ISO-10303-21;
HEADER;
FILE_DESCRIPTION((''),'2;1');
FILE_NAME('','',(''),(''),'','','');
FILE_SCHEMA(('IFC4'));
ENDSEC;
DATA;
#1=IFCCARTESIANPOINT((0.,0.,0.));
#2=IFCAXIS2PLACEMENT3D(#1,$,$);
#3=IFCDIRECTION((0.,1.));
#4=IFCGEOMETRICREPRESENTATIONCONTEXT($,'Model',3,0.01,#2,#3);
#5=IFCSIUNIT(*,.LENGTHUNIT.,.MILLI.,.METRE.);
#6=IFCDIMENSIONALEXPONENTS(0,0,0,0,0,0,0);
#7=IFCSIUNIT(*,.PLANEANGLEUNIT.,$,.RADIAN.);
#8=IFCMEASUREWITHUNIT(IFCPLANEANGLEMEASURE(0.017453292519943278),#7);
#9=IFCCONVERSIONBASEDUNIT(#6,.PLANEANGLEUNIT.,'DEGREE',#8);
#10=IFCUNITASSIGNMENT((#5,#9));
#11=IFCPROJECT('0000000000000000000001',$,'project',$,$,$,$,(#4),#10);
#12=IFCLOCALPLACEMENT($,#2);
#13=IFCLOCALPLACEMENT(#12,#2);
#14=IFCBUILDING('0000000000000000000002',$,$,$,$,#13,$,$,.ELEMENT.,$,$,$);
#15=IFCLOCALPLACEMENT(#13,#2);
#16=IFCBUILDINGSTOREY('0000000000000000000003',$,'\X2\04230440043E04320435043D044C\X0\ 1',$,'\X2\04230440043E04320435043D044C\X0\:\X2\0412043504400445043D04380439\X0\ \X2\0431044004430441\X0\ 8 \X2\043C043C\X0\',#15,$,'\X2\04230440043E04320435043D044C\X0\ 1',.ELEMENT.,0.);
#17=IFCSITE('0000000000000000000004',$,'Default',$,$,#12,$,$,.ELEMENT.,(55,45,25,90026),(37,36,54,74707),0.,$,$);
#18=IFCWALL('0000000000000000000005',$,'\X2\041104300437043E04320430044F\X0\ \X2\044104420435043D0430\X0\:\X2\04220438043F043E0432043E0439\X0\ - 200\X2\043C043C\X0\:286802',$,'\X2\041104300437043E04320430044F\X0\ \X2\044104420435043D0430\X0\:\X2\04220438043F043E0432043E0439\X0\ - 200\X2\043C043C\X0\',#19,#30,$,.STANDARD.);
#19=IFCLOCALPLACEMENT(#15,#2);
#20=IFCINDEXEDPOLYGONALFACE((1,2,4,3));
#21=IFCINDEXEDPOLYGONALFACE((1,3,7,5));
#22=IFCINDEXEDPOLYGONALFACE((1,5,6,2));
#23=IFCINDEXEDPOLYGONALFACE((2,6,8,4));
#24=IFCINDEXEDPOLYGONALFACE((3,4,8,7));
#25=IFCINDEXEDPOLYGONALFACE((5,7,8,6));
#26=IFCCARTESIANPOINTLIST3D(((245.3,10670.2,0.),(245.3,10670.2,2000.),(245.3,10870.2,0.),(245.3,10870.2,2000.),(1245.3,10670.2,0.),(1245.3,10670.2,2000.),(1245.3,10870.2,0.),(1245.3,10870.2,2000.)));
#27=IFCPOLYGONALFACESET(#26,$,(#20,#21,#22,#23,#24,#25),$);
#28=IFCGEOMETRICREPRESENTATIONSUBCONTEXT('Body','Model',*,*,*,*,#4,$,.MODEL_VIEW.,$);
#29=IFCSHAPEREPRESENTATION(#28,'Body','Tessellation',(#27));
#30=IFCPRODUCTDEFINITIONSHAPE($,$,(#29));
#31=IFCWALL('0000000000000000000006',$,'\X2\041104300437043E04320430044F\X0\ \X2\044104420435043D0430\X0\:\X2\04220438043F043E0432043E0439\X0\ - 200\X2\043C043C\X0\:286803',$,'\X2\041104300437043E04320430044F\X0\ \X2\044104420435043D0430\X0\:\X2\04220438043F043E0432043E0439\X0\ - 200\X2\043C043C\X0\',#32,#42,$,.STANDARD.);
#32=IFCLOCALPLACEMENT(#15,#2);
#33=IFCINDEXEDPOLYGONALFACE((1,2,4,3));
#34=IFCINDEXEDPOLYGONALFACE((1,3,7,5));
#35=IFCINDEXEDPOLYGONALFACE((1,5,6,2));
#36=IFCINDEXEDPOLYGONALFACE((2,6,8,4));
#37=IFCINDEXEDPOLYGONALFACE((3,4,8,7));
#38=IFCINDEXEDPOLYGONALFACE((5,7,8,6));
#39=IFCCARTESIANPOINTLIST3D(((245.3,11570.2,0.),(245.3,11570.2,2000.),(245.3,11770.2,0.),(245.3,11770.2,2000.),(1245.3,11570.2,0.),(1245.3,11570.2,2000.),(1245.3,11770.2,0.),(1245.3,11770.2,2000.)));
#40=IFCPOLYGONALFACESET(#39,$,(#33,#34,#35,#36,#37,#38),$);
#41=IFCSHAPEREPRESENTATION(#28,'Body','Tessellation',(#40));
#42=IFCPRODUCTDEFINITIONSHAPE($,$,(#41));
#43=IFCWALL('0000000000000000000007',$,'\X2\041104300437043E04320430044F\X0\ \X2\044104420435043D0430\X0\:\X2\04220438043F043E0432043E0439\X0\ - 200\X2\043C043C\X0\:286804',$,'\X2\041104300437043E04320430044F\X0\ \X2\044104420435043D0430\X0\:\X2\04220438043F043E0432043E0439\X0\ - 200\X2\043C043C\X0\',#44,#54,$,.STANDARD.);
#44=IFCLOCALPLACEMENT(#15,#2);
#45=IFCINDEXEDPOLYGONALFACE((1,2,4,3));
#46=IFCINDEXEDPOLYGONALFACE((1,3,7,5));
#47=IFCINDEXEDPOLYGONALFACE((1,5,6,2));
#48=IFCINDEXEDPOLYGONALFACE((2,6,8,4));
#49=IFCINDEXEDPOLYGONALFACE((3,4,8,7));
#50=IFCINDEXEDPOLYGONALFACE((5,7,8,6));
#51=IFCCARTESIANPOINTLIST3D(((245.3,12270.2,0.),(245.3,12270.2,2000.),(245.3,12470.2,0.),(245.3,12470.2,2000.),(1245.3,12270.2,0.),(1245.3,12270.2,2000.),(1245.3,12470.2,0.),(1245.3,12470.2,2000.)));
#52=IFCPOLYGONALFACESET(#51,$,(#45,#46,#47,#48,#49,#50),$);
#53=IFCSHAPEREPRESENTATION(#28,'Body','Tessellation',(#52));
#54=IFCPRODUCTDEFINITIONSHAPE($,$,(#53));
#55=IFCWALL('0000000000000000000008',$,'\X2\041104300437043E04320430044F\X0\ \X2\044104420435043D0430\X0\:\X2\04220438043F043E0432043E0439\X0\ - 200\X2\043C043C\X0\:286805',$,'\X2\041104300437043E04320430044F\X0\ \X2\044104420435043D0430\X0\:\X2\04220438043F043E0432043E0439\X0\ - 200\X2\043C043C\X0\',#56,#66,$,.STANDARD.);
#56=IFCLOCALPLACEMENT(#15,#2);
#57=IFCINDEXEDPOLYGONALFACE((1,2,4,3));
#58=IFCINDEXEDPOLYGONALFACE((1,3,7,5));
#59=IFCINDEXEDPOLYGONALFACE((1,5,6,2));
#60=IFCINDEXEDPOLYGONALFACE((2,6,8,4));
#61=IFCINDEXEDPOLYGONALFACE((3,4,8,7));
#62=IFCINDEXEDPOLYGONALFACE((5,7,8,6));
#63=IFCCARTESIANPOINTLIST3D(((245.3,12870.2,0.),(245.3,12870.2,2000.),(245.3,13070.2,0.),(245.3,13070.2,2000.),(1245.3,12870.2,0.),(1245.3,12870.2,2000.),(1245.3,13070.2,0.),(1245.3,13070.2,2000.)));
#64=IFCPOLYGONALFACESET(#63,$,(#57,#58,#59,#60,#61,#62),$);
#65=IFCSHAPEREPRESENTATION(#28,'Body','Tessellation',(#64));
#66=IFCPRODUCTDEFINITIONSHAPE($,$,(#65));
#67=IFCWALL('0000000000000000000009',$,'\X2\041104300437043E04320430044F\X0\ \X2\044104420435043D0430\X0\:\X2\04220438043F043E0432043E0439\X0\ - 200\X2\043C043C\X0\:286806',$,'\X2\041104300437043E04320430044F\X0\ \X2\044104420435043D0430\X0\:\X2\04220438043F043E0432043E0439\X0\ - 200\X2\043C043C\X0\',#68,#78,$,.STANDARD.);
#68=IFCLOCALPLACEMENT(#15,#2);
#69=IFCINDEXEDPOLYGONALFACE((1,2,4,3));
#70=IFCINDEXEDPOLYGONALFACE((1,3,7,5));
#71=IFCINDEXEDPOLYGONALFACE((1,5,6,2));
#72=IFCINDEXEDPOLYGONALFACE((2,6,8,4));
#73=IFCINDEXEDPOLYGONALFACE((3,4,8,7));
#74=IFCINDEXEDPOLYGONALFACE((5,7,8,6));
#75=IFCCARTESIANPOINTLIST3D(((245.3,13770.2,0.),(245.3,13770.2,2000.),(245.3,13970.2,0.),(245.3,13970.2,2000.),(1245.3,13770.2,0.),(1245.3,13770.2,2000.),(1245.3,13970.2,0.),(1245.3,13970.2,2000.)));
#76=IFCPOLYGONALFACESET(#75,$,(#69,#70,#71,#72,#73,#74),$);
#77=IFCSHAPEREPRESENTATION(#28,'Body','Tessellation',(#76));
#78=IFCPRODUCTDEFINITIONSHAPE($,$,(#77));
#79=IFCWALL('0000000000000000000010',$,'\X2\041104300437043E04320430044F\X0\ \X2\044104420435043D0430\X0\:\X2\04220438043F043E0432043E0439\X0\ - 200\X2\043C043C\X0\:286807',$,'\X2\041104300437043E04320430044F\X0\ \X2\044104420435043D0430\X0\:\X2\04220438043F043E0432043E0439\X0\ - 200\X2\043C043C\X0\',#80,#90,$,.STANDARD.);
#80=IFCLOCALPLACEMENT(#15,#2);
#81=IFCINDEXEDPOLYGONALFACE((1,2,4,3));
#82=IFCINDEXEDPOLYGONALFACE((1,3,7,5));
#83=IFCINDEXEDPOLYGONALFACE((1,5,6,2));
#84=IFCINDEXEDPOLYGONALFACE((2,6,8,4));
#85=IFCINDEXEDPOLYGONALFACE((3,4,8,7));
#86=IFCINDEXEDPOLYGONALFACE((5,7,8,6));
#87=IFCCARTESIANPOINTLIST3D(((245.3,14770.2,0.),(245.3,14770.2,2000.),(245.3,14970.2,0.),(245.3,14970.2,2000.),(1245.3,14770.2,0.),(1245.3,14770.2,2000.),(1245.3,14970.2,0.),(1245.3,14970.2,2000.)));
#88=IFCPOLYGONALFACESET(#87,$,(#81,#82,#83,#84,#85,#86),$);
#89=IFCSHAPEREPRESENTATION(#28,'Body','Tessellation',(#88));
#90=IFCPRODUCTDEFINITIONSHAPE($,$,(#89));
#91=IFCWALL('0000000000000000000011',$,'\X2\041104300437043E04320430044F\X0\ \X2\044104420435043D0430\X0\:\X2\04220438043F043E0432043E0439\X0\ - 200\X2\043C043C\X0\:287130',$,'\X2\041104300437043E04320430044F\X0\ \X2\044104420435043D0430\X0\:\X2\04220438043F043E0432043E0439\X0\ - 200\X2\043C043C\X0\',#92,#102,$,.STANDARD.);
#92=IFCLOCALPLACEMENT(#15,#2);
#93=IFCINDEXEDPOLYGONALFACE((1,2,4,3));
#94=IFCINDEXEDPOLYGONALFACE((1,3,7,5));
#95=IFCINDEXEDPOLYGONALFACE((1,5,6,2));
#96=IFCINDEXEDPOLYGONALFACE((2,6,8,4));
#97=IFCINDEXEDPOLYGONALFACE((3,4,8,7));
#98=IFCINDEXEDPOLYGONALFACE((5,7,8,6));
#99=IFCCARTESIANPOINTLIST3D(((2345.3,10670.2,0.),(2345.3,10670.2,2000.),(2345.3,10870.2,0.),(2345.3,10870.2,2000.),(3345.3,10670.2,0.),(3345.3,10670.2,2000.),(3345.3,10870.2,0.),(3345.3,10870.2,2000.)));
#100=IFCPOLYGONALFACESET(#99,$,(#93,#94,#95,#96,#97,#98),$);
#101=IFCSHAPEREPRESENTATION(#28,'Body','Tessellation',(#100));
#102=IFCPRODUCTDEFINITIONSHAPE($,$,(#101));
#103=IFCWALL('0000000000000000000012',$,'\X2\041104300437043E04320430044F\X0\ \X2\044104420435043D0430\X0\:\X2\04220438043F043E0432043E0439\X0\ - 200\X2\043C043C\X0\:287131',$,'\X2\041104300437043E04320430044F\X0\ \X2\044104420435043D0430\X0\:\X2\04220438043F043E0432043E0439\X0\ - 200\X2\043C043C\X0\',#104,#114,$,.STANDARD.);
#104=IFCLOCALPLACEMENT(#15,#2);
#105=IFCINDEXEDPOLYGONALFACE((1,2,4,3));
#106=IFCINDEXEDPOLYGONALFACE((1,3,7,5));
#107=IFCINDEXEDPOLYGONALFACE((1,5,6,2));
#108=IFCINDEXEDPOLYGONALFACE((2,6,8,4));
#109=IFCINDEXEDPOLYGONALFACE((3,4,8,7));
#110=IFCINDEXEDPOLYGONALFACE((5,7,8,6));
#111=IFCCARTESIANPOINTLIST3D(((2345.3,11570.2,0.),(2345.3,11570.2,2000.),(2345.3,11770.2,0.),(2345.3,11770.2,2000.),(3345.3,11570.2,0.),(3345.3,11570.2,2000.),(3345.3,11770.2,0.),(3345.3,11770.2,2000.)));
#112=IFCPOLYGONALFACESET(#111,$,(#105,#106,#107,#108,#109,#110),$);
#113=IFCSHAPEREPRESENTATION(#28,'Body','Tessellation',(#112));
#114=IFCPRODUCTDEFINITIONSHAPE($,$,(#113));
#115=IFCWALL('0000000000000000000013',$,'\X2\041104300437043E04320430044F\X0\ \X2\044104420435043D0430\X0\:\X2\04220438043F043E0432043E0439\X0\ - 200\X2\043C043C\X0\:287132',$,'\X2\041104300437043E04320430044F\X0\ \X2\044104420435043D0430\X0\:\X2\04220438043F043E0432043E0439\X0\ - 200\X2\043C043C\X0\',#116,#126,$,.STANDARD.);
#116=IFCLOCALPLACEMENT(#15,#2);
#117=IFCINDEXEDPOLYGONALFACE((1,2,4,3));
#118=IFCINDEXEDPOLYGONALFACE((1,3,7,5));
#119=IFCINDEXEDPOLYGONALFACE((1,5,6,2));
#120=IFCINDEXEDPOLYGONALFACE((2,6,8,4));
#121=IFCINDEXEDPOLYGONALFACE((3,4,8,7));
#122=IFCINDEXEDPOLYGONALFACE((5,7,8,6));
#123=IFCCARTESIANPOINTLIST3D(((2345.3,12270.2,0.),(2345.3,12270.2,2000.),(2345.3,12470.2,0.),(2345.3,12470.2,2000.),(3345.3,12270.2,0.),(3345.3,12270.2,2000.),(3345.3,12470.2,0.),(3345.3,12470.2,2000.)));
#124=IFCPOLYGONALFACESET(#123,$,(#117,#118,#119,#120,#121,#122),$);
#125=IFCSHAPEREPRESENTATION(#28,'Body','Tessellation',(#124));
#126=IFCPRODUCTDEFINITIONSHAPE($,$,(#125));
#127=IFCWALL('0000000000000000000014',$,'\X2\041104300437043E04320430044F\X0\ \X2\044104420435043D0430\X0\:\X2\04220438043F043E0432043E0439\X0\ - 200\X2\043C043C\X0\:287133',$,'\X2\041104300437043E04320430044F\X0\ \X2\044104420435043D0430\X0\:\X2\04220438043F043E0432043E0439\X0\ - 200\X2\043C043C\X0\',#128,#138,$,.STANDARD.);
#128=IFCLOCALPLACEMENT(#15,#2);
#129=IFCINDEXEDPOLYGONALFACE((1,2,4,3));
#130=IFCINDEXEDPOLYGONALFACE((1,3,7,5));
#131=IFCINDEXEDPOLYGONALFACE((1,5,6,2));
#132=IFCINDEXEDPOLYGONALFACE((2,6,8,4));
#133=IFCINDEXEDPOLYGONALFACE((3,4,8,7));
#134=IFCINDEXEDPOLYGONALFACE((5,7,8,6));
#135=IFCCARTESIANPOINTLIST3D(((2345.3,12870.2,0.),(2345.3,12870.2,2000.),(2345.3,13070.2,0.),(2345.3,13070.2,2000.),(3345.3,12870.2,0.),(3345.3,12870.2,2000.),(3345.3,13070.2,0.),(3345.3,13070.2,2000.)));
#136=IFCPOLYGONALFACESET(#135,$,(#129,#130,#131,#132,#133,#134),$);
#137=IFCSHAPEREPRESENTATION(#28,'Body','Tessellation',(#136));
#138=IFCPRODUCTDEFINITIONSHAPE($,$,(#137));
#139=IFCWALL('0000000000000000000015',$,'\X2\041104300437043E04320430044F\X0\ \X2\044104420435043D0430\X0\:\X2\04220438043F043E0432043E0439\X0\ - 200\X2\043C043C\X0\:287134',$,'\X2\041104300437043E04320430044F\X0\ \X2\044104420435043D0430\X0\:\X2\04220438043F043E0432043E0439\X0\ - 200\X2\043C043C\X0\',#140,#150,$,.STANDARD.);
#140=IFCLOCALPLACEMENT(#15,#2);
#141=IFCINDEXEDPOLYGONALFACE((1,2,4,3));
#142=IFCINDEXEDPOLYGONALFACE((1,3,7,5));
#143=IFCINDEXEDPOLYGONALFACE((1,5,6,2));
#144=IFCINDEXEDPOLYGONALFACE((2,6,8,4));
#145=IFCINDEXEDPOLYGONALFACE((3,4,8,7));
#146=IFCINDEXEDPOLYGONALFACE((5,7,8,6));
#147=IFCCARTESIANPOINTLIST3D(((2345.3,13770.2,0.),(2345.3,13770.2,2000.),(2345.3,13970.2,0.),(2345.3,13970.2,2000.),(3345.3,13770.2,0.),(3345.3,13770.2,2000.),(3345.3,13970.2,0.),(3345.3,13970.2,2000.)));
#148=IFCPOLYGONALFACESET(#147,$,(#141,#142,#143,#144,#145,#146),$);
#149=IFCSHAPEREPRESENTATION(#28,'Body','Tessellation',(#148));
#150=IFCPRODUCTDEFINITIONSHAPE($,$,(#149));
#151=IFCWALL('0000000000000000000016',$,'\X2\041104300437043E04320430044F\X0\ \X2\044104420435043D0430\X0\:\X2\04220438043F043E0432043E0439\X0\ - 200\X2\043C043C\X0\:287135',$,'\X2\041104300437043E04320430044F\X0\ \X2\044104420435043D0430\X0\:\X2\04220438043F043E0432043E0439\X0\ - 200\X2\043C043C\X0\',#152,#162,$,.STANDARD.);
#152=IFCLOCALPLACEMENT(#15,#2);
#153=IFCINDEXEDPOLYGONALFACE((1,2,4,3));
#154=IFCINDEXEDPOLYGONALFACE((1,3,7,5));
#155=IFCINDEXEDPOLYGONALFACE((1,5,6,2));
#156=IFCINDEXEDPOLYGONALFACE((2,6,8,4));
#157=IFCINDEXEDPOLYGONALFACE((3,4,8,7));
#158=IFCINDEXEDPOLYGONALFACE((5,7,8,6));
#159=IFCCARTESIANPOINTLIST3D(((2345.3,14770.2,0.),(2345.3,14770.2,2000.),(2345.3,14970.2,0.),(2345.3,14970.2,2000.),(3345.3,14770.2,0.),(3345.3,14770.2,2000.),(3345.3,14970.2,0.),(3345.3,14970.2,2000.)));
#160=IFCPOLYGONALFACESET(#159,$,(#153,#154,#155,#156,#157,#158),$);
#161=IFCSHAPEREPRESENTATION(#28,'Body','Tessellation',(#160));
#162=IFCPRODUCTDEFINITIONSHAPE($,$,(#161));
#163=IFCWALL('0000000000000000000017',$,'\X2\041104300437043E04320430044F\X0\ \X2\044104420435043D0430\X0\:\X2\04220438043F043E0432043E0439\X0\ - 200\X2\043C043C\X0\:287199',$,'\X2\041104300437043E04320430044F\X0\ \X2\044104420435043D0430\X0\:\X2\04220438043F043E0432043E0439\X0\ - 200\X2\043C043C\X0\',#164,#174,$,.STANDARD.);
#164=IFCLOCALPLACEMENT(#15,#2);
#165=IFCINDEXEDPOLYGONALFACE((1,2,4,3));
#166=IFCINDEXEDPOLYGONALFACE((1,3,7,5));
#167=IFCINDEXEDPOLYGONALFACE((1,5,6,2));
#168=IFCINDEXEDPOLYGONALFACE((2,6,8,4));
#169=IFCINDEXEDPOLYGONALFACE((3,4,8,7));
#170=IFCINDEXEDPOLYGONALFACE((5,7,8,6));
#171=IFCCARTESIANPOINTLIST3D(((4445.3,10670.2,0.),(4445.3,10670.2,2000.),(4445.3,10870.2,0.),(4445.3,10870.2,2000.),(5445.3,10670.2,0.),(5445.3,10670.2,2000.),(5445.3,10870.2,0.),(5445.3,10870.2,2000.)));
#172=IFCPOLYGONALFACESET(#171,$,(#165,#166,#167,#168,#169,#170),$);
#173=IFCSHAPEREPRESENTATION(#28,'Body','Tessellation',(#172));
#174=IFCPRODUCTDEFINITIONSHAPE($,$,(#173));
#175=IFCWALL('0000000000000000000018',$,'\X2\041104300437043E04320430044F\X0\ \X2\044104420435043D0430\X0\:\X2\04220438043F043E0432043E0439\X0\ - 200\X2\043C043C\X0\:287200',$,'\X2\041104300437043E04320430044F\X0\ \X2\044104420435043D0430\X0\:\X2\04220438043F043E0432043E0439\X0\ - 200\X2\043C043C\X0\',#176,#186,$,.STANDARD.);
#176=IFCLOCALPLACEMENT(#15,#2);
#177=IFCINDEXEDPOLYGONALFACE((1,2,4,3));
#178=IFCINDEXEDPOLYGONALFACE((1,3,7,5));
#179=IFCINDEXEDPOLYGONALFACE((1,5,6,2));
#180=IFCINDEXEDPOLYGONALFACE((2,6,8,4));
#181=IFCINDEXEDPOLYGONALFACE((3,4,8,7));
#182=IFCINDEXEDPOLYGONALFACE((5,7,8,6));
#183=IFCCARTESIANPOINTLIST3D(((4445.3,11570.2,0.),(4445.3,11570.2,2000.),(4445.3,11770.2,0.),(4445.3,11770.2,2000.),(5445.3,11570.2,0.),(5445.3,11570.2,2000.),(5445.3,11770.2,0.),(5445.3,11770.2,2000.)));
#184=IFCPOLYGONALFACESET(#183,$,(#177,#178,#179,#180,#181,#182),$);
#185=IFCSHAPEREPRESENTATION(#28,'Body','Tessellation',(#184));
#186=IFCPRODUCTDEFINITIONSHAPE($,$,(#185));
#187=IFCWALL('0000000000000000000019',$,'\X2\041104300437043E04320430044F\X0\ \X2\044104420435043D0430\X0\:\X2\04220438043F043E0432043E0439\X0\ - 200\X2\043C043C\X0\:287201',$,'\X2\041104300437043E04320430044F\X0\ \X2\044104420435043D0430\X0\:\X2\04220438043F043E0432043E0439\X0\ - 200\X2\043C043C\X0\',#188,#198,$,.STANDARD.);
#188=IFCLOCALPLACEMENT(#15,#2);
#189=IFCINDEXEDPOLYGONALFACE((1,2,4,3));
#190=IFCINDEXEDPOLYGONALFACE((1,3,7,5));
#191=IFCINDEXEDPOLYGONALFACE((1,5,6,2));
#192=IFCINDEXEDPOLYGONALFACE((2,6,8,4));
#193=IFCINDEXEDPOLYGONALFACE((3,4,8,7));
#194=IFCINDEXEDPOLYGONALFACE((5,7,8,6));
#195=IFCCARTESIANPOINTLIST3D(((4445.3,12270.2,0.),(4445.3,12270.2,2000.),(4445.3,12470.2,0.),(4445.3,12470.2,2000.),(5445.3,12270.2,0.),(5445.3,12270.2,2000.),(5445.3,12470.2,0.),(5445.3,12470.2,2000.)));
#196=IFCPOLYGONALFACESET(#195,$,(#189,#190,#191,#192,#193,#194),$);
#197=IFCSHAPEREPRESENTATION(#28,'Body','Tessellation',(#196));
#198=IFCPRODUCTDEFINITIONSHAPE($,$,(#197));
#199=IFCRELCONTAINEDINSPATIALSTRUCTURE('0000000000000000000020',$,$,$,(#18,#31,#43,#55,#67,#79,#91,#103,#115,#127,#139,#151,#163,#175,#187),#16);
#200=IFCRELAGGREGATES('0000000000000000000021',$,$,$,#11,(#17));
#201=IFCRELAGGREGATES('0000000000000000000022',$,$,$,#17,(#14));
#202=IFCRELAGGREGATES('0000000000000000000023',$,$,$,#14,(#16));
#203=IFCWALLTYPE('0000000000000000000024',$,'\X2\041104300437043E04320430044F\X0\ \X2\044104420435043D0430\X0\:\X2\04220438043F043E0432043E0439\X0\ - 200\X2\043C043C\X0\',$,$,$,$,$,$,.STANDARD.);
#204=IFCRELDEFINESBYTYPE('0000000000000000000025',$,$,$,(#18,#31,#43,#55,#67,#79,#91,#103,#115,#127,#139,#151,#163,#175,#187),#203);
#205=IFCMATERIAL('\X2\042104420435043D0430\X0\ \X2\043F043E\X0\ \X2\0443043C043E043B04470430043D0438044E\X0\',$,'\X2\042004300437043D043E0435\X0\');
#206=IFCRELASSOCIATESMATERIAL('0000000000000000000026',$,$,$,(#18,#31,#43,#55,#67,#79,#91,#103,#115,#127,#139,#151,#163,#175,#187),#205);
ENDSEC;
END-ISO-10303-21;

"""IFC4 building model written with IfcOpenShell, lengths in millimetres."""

from ifc_helpers import new_model, entity, si_unit, converted_unit, direction, frame, origin, place, context, subcontext, project, spatial, indexed_curve, outline, extrude, material, type_object, element, save


model = new_model("IFC4")

# Units and contexts
model_context = context("Model", 3, precision=0.01, world=origin(), true_north=direction((0.0, 1.0)))
body_context = subcontext(model_context, "Body", "Model", "MODEL_VIEW")
ifc_project = project(units=[si_unit("LENGTHUNIT", "METRE", prefix="MILLI"), converted_unit("PLANEANGLEUNIT", "DEGREE", entity("IfcPlaneAngleMeasure", 0.017453292519943278), si_unit("PLANEANGLEUNIT", "RADIAN"), dimensions=[0, 0, 0, 0, 0, 0, 0])], contexts=[model_context])

# Site, building, storey
site_placement = place(None, origin())
site = spatial("IfcSite", under=ifc_project, at=site_placement, Name="Default", CompositionType="ELEMENT", RefLatitude=(55, 45, 25, 90026), RefLongitude=(37, 36, 54, 74707), RefElevation=0.0)
building_placement = place(site_placement, origin())
building = spatial("IfcBuilding", under=site, at=building_placement, CompositionType="ELEMENT")
storey_placement = place(building_placement, origin())
storey = spatial("IfcBuildingStorey", under=building, at=storey_placement, Name="Уровень 1", ObjectType="Уровень:Верхний брус 8 мм", LongName="Уровень 1", CompositionType="ELEMENT", Elevation=0.0)

# Walls
ifc_material = material(Name="Стена по умолчанию", Category="Разное")
wall_type = type_object("IfcWallType", Name="Базовая стена:Типовой - 200мм", PredefinedType="STANDARD")
wall_1_placement = place(storey_placement, frame((245.3, 10770.2, 0.0)))
element("IfcWall", 1, at=wall_1_placement, inside=storey, type_object=wall_type, material=ifc_material, Name="Базовая стена:Типовой - 200мм:286802", ObjectType="Базовая стена:Типовой - 200мм", PredefinedType="STANDARD", context=body_context, shape_type="SweptSolid", body=[
    extrude(outline(indexed_curve([(1000.0, 100.0), (0.0, 100.0), (0.0, -100.0), (1000.0, -100.0), (1000.0, 100.0)], self_intersect=False)), origin(), (0.0, 0.0, 1.0), 2000.0),
])
for number, where, name in (
    (2, (245.3, 11670.2, 0.0), "Базовая стена:Типовой - 200мм:286803"),
    (3, (245.3, 12370.2, 0.0), "Базовая стена:Типовой - 200мм:286804"),
):
    element("IfcWall", number, at=place(storey_placement, frame(where)), inside=storey, type_object=wall_type, material=ifc_material, Name=name, ObjectType="Базовая стена:Типовой - 200мм", PredefinedType="STANDARD", context=body_context, shape_type="SweptSolid", body=[
        extrude(outline(indexed_curve([(1000.0, 100.0), (0.0, 100.0), (0.0, -100.0), (1000.0, -100.0), (1000.0, 100.0)], self_intersect=False)), origin(), (0.0, 0.0, 1.0), 2000.0),
    ])
wall_2_placement = place(storey_placement, frame((245.3, 12970.2, 0.0)))
element("IfcWall", 4, at=wall_2_placement, inside=storey, type_object=wall_type, material=ifc_material, Name="Базовая стена:Типовой - 200мм:286805", ObjectType="Базовая стена:Типовой - 200мм", PredefinedType="STANDARD", context=body_context, shape_type="SweptSolid", body=[
    extrude(outline(indexed_curve([(1000.0, 100.0), (0.0, 100.0), (0.0, -100.0), (1000.0, -100.0), (1000.0, 100.0)], self_intersect=False)), origin(), (0.0, 0.0, 1.0), 2000.0),
])
wall_3_placement = place(storey_placement, frame((245.3, 13870.2, 0.0)))
element("IfcWall", 5, at=wall_3_placement, inside=storey, type_object=wall_type, material=ifc_material, Name="Базовая стена:Типовой - 200мм:286806", ObjectType="Базовая стена:Типовой - 200мм", PredefinedType="STANDARD", context=body_context, shape_type="SweptSolid", body=[
    extrude(outline(indexed_curve([(1000.0, 100.0), (0.0, 100.0), (0.0, -100.0), (1000.0, -100.0), (1000.0, 100.0)], self_intersect=False)), origin(), (0.0, 0.0, 1.0), 2000.0),
])
wall_4_placement = place(storey_placement, frame((245.3, 14870.2, 0.0)))
element("IfcWall", 6, at=wall_4_placement, inside=storey, type_object=wall_type, material=ifc_material, Name="Базовая стена:Типовой - 200мм:286807", ObjectType="Базовая стена:Типовой - 200мм", PredefinedType="STANDARD", context=body_context, shape_type="SweptSolid", body=[
    extrude(outline(indexed_curve([(1000.0, 100.0), (0.0, 100.0), (0.0, -100.0), (1000.0, -100.0), (1000.0, 100.0)], self_intersect=False)), origin(), (0.0, 0.0, 1.0), 2000.0),
])
wall_5_placement = place(storey_placement, frame((2345.3, 10770.2, 0.0)))
element("IfcWall", 7, at=wall_5_placement, inside=storey, type_object=wall_type, material=ifc_material, Name="Базовая стена:Типовой - 200мм:287130", ObjectType="Базовая стена:Типовой - 200мм", PredefinedType="STANDARD", context=body_context, shape_type="SweptSolid", body=[
    extrude(outline(indexed_curve([(1000.0, 100.0), (0.0, 100.0), (0.0, -100.0), (1000.0, -100.0), (1000.0, 100.0)], self_intersect=False)), origin(), (0.0, 0.0, 1.0), 2000.0),
])
for number, where, name in (
    (8, (2345.3, 11670.2, 0.0), "Базовая стена:Типовой - 200мм:287131"),
    (9, (2345.3, 12370.2, 0.0), "Базовая стена:Типовой - 200мм:287132"),
):
    element("IfcWall", number, at=place(storey_placement, frame(where)), inside=storey, type_object=wall_type, material=ifc_material, Name=name, ObjectType="Базовая стена:Типовой - 200мм", PredefinedType="STANDARD", context=body_context, shape_type="SweptSolid", body=[
        extrude(outline(indexed_curve([(1000.0, 100.0), (0.0, 100.0), (0.0, -100.0), (1000.0, -100.0), (1000.0, 100.0)], self_intersect=False)), origin(), (0.0, 0.0, 1.0), 2000.0),
    ])
wall_6_placement = place(storey_placement, frame((2345.3, 12970.2, 0.0)))
element("IfcWall", 10, at=wall_6_placement, inside=storey, type_object=wall_type, material=ifc_material, Name="Базовая стена:Типовой - 200мм:287133", ObjectType="Базовая стена:Типовой - 200мм", PredefinedType="STANDARD", context=body_context, shape_type="SweptSolid", body=[
    extrude(outline(indexed_curve([(1000.0, 100.0), (0.0, 100.0), (0.0, -100.0), (1000.0, -100.0), (1000.0, 100.0)], self_intersect=False)), origin(), (0.0, 0.0, 1.0), 2000.0),
])
wall_7_placement = place(storey_placement, frame((2345.3, 13870.2, 0.0)))
element("IfcWall", 11, at=wall_7_placement, inside=storey, type_object=wall_type, material=ifc_material, Name="Базовая стена:Типовой - 200мм:287134", ObjectType="Базовая стена:Типовой - 200мм", PredefinedType="STANDARD", context=body_context, shape_type="SweptSolid", body=[
    extrude(outline(indexed_curve([(1000.0, 100.0), (0.0, 100.0), (0.0, -100.0), (1000.0, -100.0), (1000.0, 100.0)], self_intersect=False)), origin(), (0.0, 0.0, 1.0), 2000.0),
])
wall_8_placement = place(storey_placement, frame((2345.3, 14870.2, 0.0)))
element("IfcWall", 12, at=wall_8_placement, inside=storey, type_object=wall_type, material=ifc_material, Name="Базовая стена:Типовой - 200мм:287135", ObjectType="Базовая стена:Типовой - 200мм", PredefinedType="STANDARD", context=body_context, shape_type="SweptSolid", body=[
    extrude(outline(indexed_curve([(1000.0, 100.0), (0.0, 100.0), (0.0, -100.0), (1000.0, -100.0), (1000.0, 100.0)], self_intersect=False)), origin(), (0.0, 0.0, 1.0), 2000.0),
])
wall_9_placement = place(storey_placement, frame((4445.3, 10770.2, 0.0)))
element("IfcWall", 13, at=wall_9_placement, inside=storey, type_object=wall_type, material=ifc_material, Name="Базовая стена:Типовой - 200мм:287199", ObjectType="Базовая стена:Типовой - 200мм", PredefinedType="STANDARD", context=body_context, shape_type="SweptSolid", body=[
    extrude(outline(indexed_curve([(1000.0, 100.0), (0.0, 100.0), (0.0, -100.0), (1000.0, -100.0), (1000.0, 100.0)], self_intersect=False)), origin(), (0.0, 0.0, 1.0), 2000.0),
])
for number, where, name in (
    (14, (4445.3, 11670.2, 0.0), "Базовая стена:Типовой - 200мм:287200"),
    (15, (4445.3, 12370.2, 0.0), "Базовая стена:Типовой - 200мм:287201"),
):
    element("IfcWall", number, at=place(storey_placement, frame(where)), inside=storey, type_object=wall_type, material=ifc_material, Name=name, ObjectType="Базовая стена:Типовой - 200мм", PredefinedType="STANDARD", context=body_context, shape_type="SweptSolid", body=[
        extrude(outline(indexed_curve([(1000.0, 100.0), (0.0, 100.0), (0.0, -100.0), (1000.0, -100.0), (1000.0, 100.0)], self_intersect=False)), origin(), (0.0, 0.0, 1.0), 2000.0),
    ])

save(model, "model.ifc")
